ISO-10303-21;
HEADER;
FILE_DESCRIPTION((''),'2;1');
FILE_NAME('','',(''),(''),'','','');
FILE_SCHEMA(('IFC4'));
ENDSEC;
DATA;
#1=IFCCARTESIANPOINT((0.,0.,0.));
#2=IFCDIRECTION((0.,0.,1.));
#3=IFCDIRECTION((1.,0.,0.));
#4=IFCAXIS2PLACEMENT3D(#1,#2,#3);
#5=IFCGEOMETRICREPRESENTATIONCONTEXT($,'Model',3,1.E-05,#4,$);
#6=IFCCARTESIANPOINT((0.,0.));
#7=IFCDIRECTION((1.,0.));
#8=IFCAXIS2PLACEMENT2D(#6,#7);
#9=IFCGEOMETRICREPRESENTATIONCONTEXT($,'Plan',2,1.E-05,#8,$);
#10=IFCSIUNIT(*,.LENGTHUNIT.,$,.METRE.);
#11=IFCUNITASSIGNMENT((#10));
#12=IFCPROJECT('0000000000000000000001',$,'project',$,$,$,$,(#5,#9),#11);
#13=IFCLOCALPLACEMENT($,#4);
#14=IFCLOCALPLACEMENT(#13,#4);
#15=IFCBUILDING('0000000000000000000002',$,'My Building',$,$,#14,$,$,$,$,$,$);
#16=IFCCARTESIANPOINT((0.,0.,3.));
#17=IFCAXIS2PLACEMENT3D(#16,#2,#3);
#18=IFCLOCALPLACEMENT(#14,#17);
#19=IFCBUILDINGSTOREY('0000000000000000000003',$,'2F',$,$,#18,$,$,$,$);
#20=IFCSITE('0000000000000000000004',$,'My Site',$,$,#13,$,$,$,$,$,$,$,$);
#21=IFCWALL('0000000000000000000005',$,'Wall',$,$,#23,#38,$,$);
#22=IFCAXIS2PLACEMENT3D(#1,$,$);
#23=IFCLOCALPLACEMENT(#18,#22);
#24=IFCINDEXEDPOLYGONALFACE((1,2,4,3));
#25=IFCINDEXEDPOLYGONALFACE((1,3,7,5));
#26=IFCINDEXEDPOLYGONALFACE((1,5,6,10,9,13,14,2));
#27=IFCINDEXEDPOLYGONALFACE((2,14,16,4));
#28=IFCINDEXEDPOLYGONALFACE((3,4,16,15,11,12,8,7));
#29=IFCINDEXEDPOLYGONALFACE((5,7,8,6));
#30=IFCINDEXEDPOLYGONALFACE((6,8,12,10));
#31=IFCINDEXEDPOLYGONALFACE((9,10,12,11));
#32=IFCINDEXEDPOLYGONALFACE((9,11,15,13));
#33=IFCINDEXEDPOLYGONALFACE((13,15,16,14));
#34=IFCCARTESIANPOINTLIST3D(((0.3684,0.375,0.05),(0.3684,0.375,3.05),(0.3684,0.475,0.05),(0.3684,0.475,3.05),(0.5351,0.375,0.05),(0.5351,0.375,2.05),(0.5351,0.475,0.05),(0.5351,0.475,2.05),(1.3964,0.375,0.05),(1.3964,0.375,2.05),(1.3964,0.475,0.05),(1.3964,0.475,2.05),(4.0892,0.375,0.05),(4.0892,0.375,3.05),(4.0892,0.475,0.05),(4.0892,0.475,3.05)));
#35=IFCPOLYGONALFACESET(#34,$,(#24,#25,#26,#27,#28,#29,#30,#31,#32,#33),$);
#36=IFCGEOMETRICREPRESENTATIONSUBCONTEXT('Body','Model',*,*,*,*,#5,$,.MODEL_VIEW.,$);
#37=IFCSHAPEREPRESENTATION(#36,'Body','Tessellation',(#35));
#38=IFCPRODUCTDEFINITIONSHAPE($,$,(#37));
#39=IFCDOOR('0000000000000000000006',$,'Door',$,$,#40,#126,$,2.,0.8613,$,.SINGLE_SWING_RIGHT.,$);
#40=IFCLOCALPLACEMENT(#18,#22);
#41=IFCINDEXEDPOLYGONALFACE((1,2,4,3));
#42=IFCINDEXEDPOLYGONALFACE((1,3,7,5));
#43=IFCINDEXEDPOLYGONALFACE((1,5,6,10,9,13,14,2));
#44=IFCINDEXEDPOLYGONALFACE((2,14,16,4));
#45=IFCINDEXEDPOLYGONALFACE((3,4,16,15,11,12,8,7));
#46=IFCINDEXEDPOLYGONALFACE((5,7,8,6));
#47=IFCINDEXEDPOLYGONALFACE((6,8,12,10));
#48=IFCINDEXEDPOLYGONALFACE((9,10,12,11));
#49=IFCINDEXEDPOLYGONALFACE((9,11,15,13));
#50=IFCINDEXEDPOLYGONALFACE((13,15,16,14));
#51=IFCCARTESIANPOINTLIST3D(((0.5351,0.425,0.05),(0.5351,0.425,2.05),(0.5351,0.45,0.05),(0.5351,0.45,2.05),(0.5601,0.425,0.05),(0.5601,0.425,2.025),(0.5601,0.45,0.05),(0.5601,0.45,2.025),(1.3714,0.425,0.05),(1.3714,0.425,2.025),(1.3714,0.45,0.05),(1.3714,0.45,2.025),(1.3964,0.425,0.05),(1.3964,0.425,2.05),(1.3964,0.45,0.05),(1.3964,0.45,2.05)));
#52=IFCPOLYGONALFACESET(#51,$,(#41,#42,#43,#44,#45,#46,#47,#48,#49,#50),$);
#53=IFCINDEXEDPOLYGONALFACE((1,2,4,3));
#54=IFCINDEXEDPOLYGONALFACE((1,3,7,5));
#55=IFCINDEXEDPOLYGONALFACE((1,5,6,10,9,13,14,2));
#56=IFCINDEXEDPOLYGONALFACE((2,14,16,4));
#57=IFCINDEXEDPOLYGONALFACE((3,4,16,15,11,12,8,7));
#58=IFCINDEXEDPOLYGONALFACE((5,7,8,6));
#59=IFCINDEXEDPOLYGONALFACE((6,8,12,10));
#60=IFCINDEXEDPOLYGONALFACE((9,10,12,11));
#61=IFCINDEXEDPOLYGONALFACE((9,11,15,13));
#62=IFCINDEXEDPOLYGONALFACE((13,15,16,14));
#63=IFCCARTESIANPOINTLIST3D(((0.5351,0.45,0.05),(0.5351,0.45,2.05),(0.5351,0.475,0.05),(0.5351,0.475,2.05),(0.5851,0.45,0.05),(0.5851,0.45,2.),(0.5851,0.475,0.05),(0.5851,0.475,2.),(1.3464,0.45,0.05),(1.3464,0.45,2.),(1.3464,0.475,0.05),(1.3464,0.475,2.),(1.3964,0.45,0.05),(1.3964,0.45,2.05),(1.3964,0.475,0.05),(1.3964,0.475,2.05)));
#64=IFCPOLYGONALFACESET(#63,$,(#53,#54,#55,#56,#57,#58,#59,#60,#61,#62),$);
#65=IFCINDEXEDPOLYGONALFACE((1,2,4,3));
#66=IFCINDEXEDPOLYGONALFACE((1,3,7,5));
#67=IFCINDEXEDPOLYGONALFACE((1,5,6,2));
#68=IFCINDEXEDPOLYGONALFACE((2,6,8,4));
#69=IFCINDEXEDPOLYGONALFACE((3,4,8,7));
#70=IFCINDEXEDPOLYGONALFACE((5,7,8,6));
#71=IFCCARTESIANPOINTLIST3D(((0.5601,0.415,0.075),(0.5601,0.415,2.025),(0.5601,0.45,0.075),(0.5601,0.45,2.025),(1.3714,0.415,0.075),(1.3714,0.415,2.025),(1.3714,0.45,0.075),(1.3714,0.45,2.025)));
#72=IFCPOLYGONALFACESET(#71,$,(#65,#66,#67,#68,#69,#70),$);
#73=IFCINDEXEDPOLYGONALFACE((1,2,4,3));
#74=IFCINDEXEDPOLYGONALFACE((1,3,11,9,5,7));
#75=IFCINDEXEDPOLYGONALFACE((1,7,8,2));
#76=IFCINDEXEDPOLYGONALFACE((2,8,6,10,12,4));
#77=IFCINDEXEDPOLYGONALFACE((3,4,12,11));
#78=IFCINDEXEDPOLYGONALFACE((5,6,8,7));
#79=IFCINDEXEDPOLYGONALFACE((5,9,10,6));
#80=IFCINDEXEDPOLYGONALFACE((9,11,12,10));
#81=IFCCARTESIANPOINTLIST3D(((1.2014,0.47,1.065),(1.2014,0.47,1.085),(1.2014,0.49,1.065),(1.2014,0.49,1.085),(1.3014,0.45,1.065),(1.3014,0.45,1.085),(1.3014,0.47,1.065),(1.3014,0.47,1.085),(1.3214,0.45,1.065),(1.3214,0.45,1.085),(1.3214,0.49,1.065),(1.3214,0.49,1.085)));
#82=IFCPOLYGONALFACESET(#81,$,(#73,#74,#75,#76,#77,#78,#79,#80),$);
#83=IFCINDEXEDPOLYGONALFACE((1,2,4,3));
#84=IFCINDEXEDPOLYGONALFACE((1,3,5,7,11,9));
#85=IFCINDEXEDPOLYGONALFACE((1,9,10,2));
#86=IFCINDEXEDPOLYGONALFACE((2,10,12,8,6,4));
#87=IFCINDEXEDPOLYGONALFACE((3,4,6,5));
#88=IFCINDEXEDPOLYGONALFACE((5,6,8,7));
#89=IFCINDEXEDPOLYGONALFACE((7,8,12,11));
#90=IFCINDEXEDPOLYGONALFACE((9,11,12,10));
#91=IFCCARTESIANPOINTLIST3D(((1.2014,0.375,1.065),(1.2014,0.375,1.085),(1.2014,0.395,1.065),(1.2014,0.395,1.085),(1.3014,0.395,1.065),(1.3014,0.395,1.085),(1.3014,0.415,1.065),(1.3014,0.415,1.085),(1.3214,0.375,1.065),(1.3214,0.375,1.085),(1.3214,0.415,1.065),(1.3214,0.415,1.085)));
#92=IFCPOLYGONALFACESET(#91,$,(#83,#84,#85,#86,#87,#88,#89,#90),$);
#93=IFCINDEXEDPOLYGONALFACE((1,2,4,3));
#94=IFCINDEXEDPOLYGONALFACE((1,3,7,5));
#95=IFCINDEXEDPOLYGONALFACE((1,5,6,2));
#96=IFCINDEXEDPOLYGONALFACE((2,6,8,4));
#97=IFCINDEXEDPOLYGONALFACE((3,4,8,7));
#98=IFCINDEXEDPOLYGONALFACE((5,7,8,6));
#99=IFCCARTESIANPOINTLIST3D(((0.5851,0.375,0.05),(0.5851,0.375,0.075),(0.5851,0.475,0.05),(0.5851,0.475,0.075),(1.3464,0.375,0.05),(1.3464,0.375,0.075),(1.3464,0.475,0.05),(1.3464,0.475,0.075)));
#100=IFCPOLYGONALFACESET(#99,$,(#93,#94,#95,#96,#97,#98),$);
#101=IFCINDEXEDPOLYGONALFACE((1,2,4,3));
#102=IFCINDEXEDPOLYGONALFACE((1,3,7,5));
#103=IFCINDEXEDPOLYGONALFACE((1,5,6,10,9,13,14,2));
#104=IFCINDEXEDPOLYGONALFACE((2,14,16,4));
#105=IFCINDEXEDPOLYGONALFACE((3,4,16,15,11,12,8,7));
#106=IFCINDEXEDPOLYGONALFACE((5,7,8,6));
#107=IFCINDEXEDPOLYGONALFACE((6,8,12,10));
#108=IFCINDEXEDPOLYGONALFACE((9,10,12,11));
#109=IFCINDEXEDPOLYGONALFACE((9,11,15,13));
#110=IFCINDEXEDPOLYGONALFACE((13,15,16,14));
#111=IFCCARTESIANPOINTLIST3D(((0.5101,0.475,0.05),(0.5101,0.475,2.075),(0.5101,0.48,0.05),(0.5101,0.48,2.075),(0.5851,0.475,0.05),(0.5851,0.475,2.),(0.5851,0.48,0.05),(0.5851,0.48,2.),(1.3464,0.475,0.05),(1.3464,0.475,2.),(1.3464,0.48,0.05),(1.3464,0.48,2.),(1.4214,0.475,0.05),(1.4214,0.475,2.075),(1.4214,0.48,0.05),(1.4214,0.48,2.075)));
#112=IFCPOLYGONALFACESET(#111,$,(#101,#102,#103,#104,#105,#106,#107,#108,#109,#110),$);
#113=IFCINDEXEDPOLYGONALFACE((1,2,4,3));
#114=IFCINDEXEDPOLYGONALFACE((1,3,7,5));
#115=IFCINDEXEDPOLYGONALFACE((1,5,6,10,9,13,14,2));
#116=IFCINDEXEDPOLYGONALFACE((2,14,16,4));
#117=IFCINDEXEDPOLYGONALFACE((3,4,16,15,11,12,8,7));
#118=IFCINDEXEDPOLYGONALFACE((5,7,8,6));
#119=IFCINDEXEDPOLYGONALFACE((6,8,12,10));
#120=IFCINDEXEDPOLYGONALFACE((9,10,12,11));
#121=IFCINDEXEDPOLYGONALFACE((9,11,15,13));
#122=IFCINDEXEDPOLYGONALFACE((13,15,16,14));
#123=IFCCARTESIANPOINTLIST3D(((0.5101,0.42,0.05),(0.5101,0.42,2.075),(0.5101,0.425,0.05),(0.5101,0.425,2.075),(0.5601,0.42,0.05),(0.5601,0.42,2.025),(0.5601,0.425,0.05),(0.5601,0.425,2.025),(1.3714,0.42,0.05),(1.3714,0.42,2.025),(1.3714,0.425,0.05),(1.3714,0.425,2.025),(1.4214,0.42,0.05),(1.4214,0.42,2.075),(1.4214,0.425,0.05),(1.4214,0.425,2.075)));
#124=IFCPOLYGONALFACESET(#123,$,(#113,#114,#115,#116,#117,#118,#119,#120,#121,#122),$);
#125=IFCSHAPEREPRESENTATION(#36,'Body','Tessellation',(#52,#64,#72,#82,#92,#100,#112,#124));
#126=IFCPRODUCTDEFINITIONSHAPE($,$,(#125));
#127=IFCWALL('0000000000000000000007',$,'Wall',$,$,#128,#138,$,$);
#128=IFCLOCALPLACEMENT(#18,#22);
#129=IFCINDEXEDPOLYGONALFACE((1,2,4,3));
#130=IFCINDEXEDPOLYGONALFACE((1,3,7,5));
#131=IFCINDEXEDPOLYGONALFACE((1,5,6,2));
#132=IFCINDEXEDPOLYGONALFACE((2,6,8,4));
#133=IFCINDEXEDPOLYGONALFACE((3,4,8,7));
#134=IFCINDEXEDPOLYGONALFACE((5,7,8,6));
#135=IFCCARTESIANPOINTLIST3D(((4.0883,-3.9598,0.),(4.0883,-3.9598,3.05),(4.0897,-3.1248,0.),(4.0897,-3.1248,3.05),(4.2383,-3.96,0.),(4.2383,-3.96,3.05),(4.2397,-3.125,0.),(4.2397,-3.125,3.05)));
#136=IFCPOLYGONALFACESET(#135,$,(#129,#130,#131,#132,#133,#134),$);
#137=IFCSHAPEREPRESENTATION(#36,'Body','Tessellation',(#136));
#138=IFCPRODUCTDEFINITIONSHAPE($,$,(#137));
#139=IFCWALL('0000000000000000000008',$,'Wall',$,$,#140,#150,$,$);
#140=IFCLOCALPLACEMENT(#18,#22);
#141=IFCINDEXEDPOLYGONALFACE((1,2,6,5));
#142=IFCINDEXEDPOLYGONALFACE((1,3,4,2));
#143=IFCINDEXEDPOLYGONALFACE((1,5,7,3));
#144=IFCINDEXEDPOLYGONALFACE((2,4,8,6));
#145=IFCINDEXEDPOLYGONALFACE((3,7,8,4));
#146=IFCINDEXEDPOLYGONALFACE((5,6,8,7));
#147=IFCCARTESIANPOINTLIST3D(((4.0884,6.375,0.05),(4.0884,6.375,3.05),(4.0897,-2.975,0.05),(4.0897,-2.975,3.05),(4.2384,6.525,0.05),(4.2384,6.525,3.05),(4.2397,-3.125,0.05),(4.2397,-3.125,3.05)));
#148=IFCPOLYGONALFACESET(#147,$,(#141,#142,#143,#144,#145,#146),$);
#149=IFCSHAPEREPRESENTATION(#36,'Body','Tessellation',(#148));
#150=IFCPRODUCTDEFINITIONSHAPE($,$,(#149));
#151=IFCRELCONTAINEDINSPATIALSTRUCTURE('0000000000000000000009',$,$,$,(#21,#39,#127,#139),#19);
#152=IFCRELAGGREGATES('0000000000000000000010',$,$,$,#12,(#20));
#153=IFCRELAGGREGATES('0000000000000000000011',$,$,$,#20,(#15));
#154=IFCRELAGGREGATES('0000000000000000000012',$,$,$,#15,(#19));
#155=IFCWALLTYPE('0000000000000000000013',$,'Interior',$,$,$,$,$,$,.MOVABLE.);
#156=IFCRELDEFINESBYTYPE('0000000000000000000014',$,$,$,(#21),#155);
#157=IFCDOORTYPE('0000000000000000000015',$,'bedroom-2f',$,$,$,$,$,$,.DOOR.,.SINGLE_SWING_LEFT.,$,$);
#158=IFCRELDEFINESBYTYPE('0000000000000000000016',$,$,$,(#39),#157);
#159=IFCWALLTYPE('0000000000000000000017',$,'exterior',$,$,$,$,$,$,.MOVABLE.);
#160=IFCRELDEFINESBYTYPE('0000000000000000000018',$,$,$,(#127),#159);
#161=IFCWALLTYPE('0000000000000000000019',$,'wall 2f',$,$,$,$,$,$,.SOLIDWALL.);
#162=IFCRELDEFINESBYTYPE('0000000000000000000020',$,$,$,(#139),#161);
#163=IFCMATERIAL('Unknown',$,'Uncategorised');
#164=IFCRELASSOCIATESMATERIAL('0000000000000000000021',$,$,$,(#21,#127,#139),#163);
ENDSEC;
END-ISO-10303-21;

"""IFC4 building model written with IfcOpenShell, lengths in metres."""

from ifc_helpers import new_model, entity, si_unit, frame, origin_with_axes, origin_2d_with_axis, place, context, subcontext, project, spatial, line, indexed_curve, outline, extrude, shape, source, transform, mapped, material, type_object, type_shapes, element, fill, save


model = new_model("IFC4")

# Units and contexts
model_context = context("Model", 3, precision=1e-05, world=origin_with_axes())
plan_context = context("Plan", 2, precision=1e-05, world=origin_2d_with_axis())
body_context_1 = subcontext(model_context, "Body", "Model", "MODEL_VIEW")
body_context_2 = subcontext(plan_context, "Body", "Plan", "PLAN_VIEW")
ifc_project = project(units=[si_unit("LENGTHUNIT", "METRE")], contexts=[model_context, plan_context])

# Site, building, storey
site_placement = place(None, origin_with_axes())
site = spatial("IfcSite", under=ifc_project, at=site_placement, Name="My Site")
building_placement = place(site_placement, origin_with_axes())
building = spatial("IfcBuilding", under=site, at=building_placement, Name="My Building")
storey_placement = place(building_placement, frame((0.0, 0.0, 3.0), z_axis=(0.0, 0.0, 1.0), x_axis=(1.0, 0.0, 0.0)))
storey = spatial("IfcBuildingStorey", under=building, at=storey_placement, Name="2F")

# Shared definitions
ifc_material = material(Name="Unknown", Category="Uncategorised")

# Wall, opening, door
wall_type_1 = type_object("IfcWallType", Name="Interior", PredefinedType="MOVABLE")
wall_1_placement = place(storey_placement, frame((0.3684, 0.375, 0.05), z_axis=(0.0, 0.0, 1.0), x_axis=(1.0, 0.0, 0.0)))
wall_1 = element("IfcWall", 1, at=wall_1_placement, inside=storey, type_object=wall_type_1, material=ifc_material, Name="Wall", context=body_context_1, shape_type="SweptSolid", body=[
    extrude(outline(indexed_curve([(0.0, 0.0), (0.0, 0.1), (3.7209, 0.1), (3.7209, 0.0)], segments=[line(1, 2, 3, 4, 1)])), origin_with_axes(), (0.0, 0.0, 1.0), 3.0),
])
shared_shape_1 = source(origin_with_axes(), body_context_1, "Body", "SweptSolid", [
    extrude(outline(indexed_curve([(0.0, 0.0), (0.8613, 0.0), (0.8613, 2.0), (0.0, 2.0)], segments=[line(1, 2, 3, 4, 1)])), frame((0.0, -0.6, 0.0), z_axis=(0.0, -1.0, 0.0), x_axis=(1.0, 0.0, 0.0)), (0.0, 0.0, -1.0), 1.2),
])
opening_1_placement = place(wall_1_placement, frame((1.028, 0.1, 0.0), z_axis=(0.0, 0.0, 1.0), x_axis=(-1.0, 0.0, 0.0)))
opening_1 = element("IfcOpeningElement", 2, at=opening_1_placement, cuts=wall_1, PredefinedType="OPENING", context=body_context_1, shape_type="MappedRepresentation", body=[
    mapped(shared_shape_1, transform((0.0, 0.0, 0.0), x_axis=(1.0, 0.0, 0.0), y_axis=(0.0, 1.0, 0.0), z_axis=(0.0, 0.0, 1.0), scale=1.0)),
])
door_type_1 = type_object("IfcDoorType", Name="bedroom-2f", OperationType="SINGLE_SWING_LEFT", PredefinedType="DOOR")
shared_shape_2 = source(origin_with_axes(), body_context_1, "Body", "SweptSolid", [
    extrude(outline(indexed_curve([(0.0, 0.0), (0.0, 2.0), (0.8613, 2.0), (0.8613, 0.0), (0.8363, 0.0), (0.8363, 1.975), (0.025, 1.975), (0.025, 0.0)], segments=[line(1, 2, 3, 4, 5, 6, 7, 8, 1)])), frame((0.0, 0.025, 0.0), z_axis=(0.0, -1.0, 0.0), x_axis=(1.0, 0.0, 0.0)), (0.0, 0.0, -1.0), 0.025),
    extrude(outline(indexed_curve([(0.0, 0.0), (0.0, 2.0), (0.8613, 2.0), (0.8613, 0.0), (0.8113, 0.0), (0.8113, 1.95), (0.05, 1.95), (0.05, 0.0)], segments=[line(1, 2, 3, 4, 5, 6, 7, 8, 1)])), frame((0.0, 0.0, 0.0), z_axis=(0.0, -1.0, 0.0), x_axis=(1.0, 0.0, 0.0)), (0.0, 0.0, -1.0), 0.025),
    extrude(outline(indexed_curve([(0.0, 0.0), (0.8113, 0.0), (0.8113, 0.035), (0.0, 0.035)], segments=[line(1, 2, 3, 4, 1)])), frame((0.025, 0.025, 0.025), z_axis=(0.0, 0.0, 1.0), x_axis=(1.0, 0.0, 0.0)), (0.0, 0.0, 1.0), 1.95),
    extrude(outline(indexed_curve([(0.0, 0.0), (0.0, -0.04), (0.12, -0.04), (0.12, -0.02), (0.02, -0.02), (0.02, 0.0)], segments=[line(1, 2, 3, 4, 5, 6, 1)])), frame((0.075, 0.025, 1.015), z_axis=(0.0, 0.0, 1.0), x_axis=(1.0, 0.0, 0.0)), (0.0, 0.0, 1.0), 0.02),
    extrude(outline(indexed_curve([(0.0, 0.0), (0.0, 0.04), (0.12, 0.04), (0.12, 0.02), (0.02, 0.02), (0.02, 0.0)], segments=[line(1, 2, 3, 4, 5, 6, 1)])), frame((0.075, 0.06, 1.015), z_axis=(0.0, 0.0, 1.0), x_axis=(1.0, 0.0, 0.0)), (0.0, 0.0, 1.0), 0.02),
    extrude(outline(indexed_curve([(0.0, 0.0), (0.7613, 0.0), (0.7613, 0.1), (0.0, 0.1)], segments=[line(1, 2, 3, 4, 1)])), frame((0.05, 0.0, 0.0), z_axis=(0.0, 0.0, 1.0), x_axis=(1.0, 0.0, 0.0)), (0.0, 0.0, 1.0), 0.025),
    extrude(outline(indexed_curve([(0.0, 0.0), (0.0, 2.025), (0.9113, 2.025), (0.9113, 0.0), (0.8363, 0.0), (0.8363, 1.95), (0.075, 1.95), (0.075, 0.0)], segments=[line(1, 2, 3, 4, 5, 6, 7, 8, 1)])), frame((-0.025, -0.005, 0.0), z_axis=(0.0, -1.0, 0.0), x_axis=(1.0, 0.0, 0.0)), (0.0, 0.0, -1.0), 0.005),
    extrude(outline(indexed_curve([(0.0, 0.0), (0.0, 2.025), (0.9113, 2.025), (0.9113, 0.0), (0.8613, 0.0), (0.8613, 1.975), (0.05, 1.975), (0.05, 0.0)], segments=[line(1, 2, 3, 4, 5, 6, 7, 8, 1)])), frame((-0.025, 0.05, 0.0), z_axis=(0.0, -1.0, 0.0), x_axis=(1.0, 0.0, 0.0)), (0.0, 0.0, -1.0), 0.005),
])
shared_shape_3 = source(origin_with_axes(), body_context_2, "Body", "Curve2D", [
    entity("IfcIndexedPolyCurve", entity("IfcCartesianPointList2D", [[0.0, 0.0], [0.0, 0.05], [0.025, 0.05], [0.025, 0.025], [0.05, 0.025], [0.05, 0.0]]), [entity("IfcLineIndex", [1, 2, 3, 4, 5, 6, 1])]),
    entity("IfcIndexedPolyCurve", entity("IfcCartesianPointList2D", [[0.8613, 0.0], [0.8613, 0.05], [0.8363, 0.05], [0.8363, 0.025], [0.8113, 0.025], [0.8113, 0.0]]), [entity("IfcLineIndex", [1, 2, 3, 4, 5, 6, 1])]),
    entity("IfcTrimmedCurve", entity("IfcEllipse", entity("IfcAxis2Placement2D", entity("IfcCartesianPoint", [0.8013, 0.05]), entity("IfcDirection", [1.0, 0.0])), 0.7763, 0.8113), [entity("IfcCartesianPoint", [0.8013, 0.8613])], [entity("IfcCartesianPoint", [0.025, 0.05])], True, "CARTESIAN"),
    entity("IfcIndexedPolyCurve", entity("IfcCartesianPointList2D", [[0.8363, 0.05], [0.8013, 0.05], [0.8013, 0.8613], [0.8363, 0.8613]]), [entity("IfcLineIndex", [1, 2, 3, 4, 1])]),
])
type_shapes(door_type_1, [shared_shape_2, shared_shape_3])
door_1_placement = place(opening_1_placement, origin_with_axes())
door_1 = element("IfcDoor", 3, at=door_1_placement, inside=storey, type_object=door_type_1, Name="Door", OperationType="SINGLE_SWING_RIGHT", OverallHeight=2.0, OverallWidth=0.8613, shapes=[
    shape(body_context_1, "Body", "MappedRepresentation", [mapped(shared_shape_2, transform((0.0, 0.0, 0.0), x_axis=(1.0, 0.0, 0.0), y_axis=(0.0, 1.0, 0.0), z_axis=(0.0, 0.0, 1.0), scale=1.0))]),
    shape(body_context_2, "Body", "MappedRepresentation", [mapped(shared_shape_3, transform((0.0, 0.0, 0.0), x_axis=(1.0, 0.0, 0.0), y_axis=(0.0, 1.0, 0.0), z_axis=(0.0, 0.0, 1.0), scale=1.0))]),
])
fill(opening_1, door_1)

# Walls
wall_type_2 = type_object("IfcWallType", Name="exterior", PredefinedType="MOVABLE")
wall_2_placement = place(storey_placement, frame((4.2383, -3.96, 0.0), z_axis=(0.0, 0.0, 1.0), x_axis=(0.00165, 0.999999, 0.0)))
element("IfcWall", 4, at=wall_2_placement, inside=storey, type_object=wall_type_2, material=ifc_material, Name="Wall", context=body_context_1, shape_type="SweptSolid", body=[
    extrude(outline(indexed_curve([(0.0, 0.0), (0.0, 0.15), (0.835, 0.15), (0.835, 0.0)], segments=[line(1, 2, 3, 4, 1)])), origin_with_axes(), (0.0, 0.0, 1.0), 3.05),
])
wall_type_3 = type_object("IfcWallType", Name="wall 2f", PredefinedType="SOLIDWALL")
wall_3_placement = place(storey_placement, frame((4.2397, -3.125, 0.05), z_axis=(0.0, 0.0, 1.0), x_axis=(-0.000142, 1.0, 0.0)))
element("IfcWall", 5, at=wall_3_placement, inside=storey, type_object=wall_type_3, material=ifc_material, Name="Wall", context=body_context_1, shape_type="SweptSolid", body=[
    extrude(outline(indexed_curve([(0.0, 0.0), (0.15, 0.15), (9.5, 0.15), (9.65, 0.0)], segments=[line(1, 2, 3, 4, 1)])), origin_with_axes(), (0.0, 0.0, 1.0), 3.0),
])

save(model, "model.ifc")
